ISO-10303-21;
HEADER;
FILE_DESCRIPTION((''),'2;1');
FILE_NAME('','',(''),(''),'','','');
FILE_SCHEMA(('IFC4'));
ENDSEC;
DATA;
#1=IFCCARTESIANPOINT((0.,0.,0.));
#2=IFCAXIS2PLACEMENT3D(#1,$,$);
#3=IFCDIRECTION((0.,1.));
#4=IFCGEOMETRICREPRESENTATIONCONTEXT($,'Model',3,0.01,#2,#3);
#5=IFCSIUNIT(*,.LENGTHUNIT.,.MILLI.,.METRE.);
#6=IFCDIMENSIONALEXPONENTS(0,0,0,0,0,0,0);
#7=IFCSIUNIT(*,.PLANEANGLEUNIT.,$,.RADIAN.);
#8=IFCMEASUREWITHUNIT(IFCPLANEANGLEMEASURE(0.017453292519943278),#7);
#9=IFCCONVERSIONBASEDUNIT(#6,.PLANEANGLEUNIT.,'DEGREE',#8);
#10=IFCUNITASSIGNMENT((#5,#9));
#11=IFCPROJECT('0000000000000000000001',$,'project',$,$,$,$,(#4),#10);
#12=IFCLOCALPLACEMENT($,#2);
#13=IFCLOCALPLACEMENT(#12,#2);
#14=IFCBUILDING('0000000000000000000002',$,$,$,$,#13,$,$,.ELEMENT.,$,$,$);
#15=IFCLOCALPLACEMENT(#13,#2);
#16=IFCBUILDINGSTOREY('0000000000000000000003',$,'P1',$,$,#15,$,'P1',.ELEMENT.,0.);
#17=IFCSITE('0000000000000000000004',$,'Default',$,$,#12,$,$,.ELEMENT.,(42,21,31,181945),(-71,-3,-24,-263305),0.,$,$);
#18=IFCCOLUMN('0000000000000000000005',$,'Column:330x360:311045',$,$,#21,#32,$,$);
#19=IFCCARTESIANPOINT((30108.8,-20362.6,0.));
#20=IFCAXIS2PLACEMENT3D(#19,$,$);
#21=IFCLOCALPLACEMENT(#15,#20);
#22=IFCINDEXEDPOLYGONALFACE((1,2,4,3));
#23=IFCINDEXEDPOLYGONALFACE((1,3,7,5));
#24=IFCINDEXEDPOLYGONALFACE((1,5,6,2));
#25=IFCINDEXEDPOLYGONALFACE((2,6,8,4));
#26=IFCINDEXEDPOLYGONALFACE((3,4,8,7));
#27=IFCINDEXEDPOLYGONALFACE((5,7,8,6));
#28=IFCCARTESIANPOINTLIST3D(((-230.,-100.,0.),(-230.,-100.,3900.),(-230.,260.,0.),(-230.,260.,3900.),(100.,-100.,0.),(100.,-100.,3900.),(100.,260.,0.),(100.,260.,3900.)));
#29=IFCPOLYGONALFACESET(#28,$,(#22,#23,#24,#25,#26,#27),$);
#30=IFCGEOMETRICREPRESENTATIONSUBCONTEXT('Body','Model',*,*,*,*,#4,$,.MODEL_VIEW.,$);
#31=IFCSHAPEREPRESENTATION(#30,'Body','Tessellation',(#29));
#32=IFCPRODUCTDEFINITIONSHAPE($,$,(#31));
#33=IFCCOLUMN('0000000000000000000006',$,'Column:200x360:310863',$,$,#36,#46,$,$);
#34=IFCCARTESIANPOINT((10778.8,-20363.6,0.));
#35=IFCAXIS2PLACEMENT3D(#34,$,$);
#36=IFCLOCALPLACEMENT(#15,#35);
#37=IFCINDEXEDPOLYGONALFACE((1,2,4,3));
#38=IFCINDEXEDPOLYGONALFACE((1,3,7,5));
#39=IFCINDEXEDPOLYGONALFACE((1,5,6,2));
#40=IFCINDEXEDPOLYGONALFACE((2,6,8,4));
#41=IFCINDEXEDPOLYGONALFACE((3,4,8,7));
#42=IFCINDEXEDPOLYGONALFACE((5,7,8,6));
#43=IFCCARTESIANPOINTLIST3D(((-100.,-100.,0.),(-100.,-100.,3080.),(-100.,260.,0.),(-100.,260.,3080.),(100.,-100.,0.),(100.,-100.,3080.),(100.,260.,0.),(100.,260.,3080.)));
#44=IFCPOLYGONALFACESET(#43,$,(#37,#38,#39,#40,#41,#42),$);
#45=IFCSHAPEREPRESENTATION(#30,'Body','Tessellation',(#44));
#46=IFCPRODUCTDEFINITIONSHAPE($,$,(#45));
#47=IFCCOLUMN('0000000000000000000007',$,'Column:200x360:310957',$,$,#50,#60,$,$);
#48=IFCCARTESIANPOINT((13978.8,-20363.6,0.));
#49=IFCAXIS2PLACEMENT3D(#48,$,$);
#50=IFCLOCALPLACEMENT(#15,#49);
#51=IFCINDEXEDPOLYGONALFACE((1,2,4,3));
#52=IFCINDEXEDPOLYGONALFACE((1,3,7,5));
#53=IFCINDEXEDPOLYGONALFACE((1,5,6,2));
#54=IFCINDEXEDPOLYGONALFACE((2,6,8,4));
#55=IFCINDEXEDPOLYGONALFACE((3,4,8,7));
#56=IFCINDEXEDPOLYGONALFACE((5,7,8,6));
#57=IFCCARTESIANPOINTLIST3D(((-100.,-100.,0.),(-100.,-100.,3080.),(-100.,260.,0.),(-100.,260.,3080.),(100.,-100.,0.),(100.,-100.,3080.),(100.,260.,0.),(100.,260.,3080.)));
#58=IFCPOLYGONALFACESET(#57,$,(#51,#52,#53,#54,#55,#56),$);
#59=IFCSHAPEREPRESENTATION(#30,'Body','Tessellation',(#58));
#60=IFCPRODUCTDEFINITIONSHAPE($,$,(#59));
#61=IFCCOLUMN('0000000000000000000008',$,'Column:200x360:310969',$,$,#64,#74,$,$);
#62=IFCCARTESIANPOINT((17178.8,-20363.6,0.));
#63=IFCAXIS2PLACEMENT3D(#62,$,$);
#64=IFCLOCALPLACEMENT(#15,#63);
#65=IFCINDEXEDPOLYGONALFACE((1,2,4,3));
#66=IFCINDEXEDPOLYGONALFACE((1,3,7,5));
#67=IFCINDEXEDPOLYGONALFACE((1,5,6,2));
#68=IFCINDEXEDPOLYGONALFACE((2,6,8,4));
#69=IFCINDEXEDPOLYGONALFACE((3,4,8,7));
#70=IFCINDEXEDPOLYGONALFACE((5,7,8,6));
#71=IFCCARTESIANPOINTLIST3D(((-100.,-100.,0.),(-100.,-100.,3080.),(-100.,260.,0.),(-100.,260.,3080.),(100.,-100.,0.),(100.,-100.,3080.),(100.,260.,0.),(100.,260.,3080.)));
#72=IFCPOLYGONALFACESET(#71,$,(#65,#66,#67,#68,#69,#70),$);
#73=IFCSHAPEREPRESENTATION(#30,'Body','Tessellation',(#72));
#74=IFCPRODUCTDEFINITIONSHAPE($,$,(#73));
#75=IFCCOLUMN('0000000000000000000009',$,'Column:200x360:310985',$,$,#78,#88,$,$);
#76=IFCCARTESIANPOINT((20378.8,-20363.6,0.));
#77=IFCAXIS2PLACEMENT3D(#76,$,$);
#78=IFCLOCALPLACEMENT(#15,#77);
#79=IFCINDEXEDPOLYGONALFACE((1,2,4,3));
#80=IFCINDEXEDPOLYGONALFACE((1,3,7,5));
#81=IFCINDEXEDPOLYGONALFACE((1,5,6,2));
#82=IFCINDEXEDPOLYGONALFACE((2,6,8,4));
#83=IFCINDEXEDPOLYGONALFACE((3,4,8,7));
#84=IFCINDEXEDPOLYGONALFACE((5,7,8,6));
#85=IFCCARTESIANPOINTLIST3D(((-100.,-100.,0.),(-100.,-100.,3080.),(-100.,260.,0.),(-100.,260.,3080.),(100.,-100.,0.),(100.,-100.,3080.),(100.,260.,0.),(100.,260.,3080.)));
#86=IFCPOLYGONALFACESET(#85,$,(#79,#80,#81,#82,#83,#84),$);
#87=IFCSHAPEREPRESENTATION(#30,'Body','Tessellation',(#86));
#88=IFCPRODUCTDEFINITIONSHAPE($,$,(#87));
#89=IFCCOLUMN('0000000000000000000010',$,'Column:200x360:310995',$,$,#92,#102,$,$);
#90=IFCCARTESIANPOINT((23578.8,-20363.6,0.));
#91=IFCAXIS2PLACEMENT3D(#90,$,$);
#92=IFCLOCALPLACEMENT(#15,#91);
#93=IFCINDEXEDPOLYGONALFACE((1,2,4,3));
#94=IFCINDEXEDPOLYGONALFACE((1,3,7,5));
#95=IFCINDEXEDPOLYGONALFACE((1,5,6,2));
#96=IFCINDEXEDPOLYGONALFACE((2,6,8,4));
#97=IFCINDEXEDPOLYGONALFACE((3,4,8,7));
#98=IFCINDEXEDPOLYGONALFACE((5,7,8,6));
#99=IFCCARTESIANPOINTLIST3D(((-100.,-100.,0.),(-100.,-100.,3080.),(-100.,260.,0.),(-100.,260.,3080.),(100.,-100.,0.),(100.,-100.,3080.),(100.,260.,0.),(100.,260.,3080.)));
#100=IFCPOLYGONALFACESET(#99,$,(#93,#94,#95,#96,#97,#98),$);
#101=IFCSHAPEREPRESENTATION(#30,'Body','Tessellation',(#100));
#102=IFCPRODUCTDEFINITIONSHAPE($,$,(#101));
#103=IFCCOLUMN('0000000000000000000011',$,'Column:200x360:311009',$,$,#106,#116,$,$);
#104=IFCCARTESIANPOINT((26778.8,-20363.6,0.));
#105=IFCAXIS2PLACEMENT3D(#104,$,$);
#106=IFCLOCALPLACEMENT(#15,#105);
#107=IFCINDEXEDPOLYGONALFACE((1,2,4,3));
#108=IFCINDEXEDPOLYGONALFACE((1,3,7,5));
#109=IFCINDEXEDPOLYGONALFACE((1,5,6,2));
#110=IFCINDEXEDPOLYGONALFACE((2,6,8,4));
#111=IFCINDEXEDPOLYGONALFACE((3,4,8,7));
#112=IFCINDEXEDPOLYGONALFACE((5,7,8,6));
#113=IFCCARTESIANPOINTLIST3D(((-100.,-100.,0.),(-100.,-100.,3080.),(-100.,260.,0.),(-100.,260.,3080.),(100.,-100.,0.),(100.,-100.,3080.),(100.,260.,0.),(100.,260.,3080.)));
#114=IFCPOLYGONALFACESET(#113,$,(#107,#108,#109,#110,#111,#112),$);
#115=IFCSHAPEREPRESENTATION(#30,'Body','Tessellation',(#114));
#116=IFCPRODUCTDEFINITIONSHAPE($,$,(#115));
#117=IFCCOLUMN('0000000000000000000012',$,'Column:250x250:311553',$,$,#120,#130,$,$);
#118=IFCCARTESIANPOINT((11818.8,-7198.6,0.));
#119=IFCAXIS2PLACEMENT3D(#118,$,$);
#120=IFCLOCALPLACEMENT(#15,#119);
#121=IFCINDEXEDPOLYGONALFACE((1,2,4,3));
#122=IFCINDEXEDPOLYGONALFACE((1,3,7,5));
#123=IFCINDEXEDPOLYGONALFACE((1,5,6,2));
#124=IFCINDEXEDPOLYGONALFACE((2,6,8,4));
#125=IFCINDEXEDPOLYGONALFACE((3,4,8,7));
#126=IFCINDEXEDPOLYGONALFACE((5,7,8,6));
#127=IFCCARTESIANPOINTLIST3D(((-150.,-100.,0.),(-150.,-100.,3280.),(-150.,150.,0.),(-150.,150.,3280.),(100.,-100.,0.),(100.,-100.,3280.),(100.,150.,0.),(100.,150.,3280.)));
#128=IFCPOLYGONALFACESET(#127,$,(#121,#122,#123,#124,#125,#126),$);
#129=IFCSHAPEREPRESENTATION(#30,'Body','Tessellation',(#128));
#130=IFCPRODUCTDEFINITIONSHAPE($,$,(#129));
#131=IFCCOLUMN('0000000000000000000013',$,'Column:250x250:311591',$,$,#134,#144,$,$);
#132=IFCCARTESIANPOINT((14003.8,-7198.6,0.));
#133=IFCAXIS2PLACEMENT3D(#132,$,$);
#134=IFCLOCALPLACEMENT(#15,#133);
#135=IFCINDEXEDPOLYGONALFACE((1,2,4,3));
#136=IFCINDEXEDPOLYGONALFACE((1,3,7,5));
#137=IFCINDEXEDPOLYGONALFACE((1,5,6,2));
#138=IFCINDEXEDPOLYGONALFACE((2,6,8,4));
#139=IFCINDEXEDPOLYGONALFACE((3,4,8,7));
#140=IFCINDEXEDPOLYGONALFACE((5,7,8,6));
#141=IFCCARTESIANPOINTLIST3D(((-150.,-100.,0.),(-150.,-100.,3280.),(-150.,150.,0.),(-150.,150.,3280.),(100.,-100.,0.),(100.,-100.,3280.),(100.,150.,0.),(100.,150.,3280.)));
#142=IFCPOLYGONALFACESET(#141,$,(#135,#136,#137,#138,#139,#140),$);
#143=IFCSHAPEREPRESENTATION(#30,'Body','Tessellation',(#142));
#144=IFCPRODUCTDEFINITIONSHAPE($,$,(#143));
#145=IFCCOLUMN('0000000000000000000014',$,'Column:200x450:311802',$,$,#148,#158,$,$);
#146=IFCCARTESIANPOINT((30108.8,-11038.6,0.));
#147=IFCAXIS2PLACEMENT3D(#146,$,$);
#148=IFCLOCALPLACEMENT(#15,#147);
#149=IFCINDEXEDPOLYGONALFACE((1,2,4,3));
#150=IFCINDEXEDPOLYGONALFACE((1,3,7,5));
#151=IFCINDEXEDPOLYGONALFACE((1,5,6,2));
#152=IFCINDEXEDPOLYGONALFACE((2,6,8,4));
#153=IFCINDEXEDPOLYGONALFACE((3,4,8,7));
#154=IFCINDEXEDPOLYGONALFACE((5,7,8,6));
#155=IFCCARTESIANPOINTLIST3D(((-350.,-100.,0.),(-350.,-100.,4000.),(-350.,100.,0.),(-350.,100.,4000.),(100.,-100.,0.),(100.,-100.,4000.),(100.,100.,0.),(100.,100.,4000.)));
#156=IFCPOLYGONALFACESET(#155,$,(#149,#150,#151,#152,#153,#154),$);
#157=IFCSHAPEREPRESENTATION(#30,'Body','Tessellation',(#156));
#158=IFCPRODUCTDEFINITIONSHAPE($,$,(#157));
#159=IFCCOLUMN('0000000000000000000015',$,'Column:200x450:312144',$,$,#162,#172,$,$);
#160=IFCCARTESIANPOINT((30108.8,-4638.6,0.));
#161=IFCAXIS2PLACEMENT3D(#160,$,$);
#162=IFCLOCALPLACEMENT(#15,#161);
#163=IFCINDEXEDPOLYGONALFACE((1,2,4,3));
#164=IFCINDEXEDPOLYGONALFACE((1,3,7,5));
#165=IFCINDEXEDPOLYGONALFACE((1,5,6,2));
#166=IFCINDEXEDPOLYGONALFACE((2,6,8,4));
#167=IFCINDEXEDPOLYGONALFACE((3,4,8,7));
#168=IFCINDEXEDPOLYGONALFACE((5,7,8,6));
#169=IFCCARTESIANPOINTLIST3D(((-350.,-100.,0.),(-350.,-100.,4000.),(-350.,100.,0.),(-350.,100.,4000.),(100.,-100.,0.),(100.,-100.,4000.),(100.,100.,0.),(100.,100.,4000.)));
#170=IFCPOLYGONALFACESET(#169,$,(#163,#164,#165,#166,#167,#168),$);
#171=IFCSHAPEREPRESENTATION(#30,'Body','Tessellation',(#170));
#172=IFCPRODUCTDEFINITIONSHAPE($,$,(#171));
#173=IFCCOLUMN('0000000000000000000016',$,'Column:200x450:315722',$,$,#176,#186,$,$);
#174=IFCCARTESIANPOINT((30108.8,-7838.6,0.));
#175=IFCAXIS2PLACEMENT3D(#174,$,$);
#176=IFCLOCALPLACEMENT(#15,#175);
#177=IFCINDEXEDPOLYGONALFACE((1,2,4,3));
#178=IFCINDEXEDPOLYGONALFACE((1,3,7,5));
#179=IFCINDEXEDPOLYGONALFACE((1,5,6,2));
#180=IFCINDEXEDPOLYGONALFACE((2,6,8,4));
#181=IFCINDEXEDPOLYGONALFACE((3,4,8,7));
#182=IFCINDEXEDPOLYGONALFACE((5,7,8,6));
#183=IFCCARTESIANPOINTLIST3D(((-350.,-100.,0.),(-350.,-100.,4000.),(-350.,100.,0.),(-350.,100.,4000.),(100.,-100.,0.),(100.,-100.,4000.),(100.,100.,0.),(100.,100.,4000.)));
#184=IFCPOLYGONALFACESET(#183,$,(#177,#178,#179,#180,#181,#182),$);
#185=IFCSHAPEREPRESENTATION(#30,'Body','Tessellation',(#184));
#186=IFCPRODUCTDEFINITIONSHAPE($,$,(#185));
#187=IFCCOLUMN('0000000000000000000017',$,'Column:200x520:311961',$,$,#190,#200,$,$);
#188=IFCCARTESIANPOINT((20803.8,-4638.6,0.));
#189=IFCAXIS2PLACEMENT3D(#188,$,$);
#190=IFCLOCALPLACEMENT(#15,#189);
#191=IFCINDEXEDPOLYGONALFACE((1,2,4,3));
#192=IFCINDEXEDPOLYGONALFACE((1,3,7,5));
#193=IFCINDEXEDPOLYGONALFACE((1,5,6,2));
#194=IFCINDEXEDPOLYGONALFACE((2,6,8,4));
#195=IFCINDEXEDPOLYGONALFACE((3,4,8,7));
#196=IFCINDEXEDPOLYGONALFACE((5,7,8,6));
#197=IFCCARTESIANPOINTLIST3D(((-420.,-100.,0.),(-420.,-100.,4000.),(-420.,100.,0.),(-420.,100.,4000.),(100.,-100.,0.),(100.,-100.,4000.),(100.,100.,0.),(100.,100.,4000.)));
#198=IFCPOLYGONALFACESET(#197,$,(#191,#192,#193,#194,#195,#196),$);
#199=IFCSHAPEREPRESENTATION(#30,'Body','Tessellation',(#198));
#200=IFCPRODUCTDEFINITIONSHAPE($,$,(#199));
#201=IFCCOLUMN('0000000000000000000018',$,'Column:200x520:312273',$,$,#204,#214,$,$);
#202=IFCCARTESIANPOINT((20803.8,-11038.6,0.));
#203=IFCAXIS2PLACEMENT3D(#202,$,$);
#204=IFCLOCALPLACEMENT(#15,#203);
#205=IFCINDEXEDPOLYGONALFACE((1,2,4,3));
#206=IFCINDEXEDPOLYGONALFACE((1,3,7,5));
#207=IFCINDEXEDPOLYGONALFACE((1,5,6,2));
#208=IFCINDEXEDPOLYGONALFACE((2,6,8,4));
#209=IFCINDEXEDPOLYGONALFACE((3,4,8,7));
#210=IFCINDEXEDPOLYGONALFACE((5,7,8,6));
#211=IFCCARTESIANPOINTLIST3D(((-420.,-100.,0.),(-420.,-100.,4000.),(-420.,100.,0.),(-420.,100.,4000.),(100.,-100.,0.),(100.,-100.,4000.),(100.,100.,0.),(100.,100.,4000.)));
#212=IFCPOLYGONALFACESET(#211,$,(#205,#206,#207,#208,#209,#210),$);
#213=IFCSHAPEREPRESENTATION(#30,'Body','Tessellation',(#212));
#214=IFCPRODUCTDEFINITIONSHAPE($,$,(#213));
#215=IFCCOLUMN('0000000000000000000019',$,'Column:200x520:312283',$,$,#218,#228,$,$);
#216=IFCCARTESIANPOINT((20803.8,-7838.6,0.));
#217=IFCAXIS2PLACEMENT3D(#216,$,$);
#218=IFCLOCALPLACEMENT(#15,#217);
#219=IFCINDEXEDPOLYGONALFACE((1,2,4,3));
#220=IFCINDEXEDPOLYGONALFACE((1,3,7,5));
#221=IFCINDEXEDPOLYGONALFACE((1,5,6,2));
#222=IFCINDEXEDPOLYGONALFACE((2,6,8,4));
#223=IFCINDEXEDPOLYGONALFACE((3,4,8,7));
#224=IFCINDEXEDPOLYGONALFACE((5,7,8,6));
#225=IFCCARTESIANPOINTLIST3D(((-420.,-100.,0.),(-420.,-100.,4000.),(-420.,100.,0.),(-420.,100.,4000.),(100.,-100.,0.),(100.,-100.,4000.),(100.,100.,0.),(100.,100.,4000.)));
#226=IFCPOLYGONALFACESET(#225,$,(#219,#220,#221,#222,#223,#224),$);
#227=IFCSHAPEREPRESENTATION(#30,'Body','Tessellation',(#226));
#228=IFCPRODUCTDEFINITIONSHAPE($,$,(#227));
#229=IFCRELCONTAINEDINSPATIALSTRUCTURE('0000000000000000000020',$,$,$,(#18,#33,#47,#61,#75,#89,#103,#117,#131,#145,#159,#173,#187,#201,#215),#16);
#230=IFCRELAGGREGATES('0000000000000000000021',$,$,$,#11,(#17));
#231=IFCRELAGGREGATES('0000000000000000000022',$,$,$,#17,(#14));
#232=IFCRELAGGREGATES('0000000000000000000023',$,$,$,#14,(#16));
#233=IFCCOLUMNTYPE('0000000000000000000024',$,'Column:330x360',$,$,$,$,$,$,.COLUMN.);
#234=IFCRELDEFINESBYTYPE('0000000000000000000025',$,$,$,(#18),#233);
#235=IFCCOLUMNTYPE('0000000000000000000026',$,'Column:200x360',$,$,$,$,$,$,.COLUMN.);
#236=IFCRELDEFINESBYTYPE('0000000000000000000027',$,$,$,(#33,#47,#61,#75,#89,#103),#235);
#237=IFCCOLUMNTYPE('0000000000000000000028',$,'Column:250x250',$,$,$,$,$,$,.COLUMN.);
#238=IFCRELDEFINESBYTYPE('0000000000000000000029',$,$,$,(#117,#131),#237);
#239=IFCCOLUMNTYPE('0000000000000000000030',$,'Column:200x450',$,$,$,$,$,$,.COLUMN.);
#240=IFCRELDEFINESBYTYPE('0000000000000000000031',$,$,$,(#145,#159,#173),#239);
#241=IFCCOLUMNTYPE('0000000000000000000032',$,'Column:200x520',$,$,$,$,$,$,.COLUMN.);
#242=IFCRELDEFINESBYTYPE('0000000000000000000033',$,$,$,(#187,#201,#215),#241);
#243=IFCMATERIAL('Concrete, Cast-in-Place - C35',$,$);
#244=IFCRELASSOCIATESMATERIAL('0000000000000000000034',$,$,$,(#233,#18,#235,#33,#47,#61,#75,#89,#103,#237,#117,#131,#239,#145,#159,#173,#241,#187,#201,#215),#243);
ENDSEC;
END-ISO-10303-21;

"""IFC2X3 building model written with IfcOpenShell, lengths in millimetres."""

from ifc_helpers import new_model, entity, si_unit, converted_unit, direction, frame, origin, origin_2d_with_axis, place, context, subcontext, project, spatial, rectangle, extrude, source, transform, mapped, material, type_object, type_shapes, element, save


model = new_model("IFC2X3")

# Units and contexts
model_context = context("Model", 3, precision=0.01, world=origin(), true_north=direction((0.0, 1.0)))
body_context = subcontext(model_context, "Body", "Model", "MODEL_VIEW")
ifc_project = project(units=[si_unit("LENGTHUNIT", "METRE", prefix="MILLI"), converted_unit("PLANEANGLEUNIT", "DEGREE", entity("IfcPlaneAngleMeasure", 0.017453292519943278), si_unit("PLANEANGLEUNIT", "RADIAN"), dimensions=[0, 0, 0, 0, 0, 0, 0])], contexts=[model_context])

# Site, building, storey
site_placement = place(None, origin())
site = spatial("IfcSite", under=ifc_project, at=site_placement, Name="Default", CompositionType="ELEMENT", RefLatitude=(42, 21, 31, 181945), RefLongitude=(-71, -3, -24, -263305), RefElevation=0.0)
building_placement = place(site_placement, origin())
building = spatial("IfcBuilding", under=site, at=building_placement, CompositionType="ELEMENT")
storey_placement = place(building_placement, origin())
storey = spatial("IfcBuildingStorey", under=building, at=storey_placement, Name="P1", LongName="P1", CompositionType="ELEMENT", Elevation=0.0)

# Columns
ifc_material_1 = material(Name="Concrete, Cast-in-Place - C35")
column_type_1 = type_object("IfcColumnType", Name="Column:330x360", PredefinedType="COLUMN", material=ifc_material_1)
shared_shape_1 = source(origin(), body_context, "Body", "SweptSolid", [
    extrude(rectangle(XDim=330.0, YDim=360.0, at=origin_2d_with_axis()), frame((-65.0, 80.0, 0.0), z_axis=(0.0, 0.0, 1.0), x_axis=(-1.0, 0.0, 0.0)), (0.0, 0.0, 1.0), 3900.0),
])
type_shapes(column_type_1, [shared_shape_1])
column_placement = place(storey_placement, frame((30108.8, -20362.6, 0.0)))
element("IfcColumn", 1, at=column_placement, inside=storey, type_object=column_type_1, material=ifc_material_1, Name="Column:330x360:311045", context=body_context, shape_type="MappedRepresentation", body=[
    mapped(shared_shape_1, transform((0.0, 0.0, 0.0), scale=1.0)),
])
column_type_2 = type_object("IfcColumnType", Name="Column:200x360", PredefinedType="COLUMN", material=ifc_material_1)
shared_shape_2 = source(origin(), body_context, "Body", "SweptSolid", [
    extrude(rectangle(XDim=200.0, YDim=360.0, at=origin_2d_with_axis()), frame((0.0, 80.0, 0.0), z_axis=(0.0, 0.0, 1.0), x_axis=(-1.0, 0.0, 0.0)), (0.0, 0.0, 1.0), 3080.0),
])
type_shapes(column_type_2, [shared_shape_2])
for number, where, name in (
    (2, (10778.8, -20363.6, 0.0), "Column:200x360:310863"),
    (3, (13978.8, -20363.6, 0.0), "Column:200x360:310957"),
    (4, (17178.8, -20363.6, 0.0), "Column:200x360:310969"),
    (5, (20378.8, -20363.6, 0.0), "Column:200x360:310985"),
    (6, (23578.8, -20363.6, 0.0), "Column:200x360:310995"),
    (7, (26778.8, -20363.6, 0.0), "Column:200x360:311009"),
):
    element("IfcColumn", number, at=place(storey_placement, frame(where)), inside=storey, type_object=column_type_2, material=ifc_material_1, Name=name, context=body_context, shape_type="MappedRepresentation", body=[
        mapped(shared_shape_2, transform((0.0, 0.0, 0.0), scale=1.0)),
    ])
column_type_3 = type_object("IfcColumnType", Name="Column:250x250", PredefinedType="COLUMN", material=ifc_material_1)
shared_shape_3 = source(origin(), body_context, "Body", "SweptSolid", [
    extrude(rectangle(XDim=250.0, YDim=250.0, at=origin_2d_with_axis()), frame((-25.0, 25.0, 0.0), z_axis=(0.0, 0.0, 1.0), x_axis=(-1.0, 0.0, 0.0)), (0.0, 0.0, 1.0), 3280.0),
])
type_shapes(column_type_3, [shared_shape_3])
for number, where, name in (
    (8, (11818.8, -7198.6, 0.0), "Column:250x250:311553"),
    (9, (14003.8, -7198.6, 0.0), "Column:250x250:311591"),
):
    element("IfcColumn", number, at=place(storey_placement, frame(where)), inside=storey, type_object=column_type_3, material=ifc_material_1, Name=name, context=body_context, shape_type="MappedRepresentation", body=[
        mapped(shared_shape_3, transform((0.0, 0.0, 0.0), scale=1.0)),
    ])
column_type_4 = type_object("IfcColumnType", Name="Column:200x450", PredefinedType="COLUMN", material=ifc_material_1)
shared_shape_4 = source(origin(), body_context, "Body", "SweptSolid", [
    extrude(rectangle(XDim=450.0, YDim=200.0, at=origin_2d_with_axis()), frame((-125.0, 0.0, 0.0), z_axis=(0.0, 0.0, 1.0), x_axis=(-1.0, 0.0, 0.0)), (0.0, 0.0, 1.0), 4000.0),
])
type_shapes(column_type_4, [shared_shape_4])
for number, where, name in (
    (10, (30108.8, -11038.6, 0.0), "Column:200x450:311802"),
    (11, (30108.8, -4638.6, 0.0), "Column:200x450:312144"),
    (12, (30108.8, -7838.6, 0.0), "Column:200x450:315722"),
):
    element("IfcColumn", number, at=place(storey_placement, frame(where)), inside=storey, type_object=column_type_4, material=ifc_material_1, Name=name, context=body_context, shape_type="MappedRepresentation", body=[
        mapped(shared_shape_4, transform((0.0, 0.0, 0.0), scale=1.0)),
    ])
column_type_5 = type_object("IfcColumnType", Name="Column:200x520", PredefinedType="COLUMN", material=ifc_material_1)
shared_shape_5 = source(origin(), body_context, "Body", "SweptSolid", [
    extrude(rectangle(XDim=520.0, YDim=200.0, at=origin_2d_with_axis()), frame((-160.0, 0.0, 0.0), z_axis=(0.0, 0.0, 1.0), x_axis=(-1.0, 0.0, 0.0)), (0.0, 0.0, 1.0), 4000.0),
])
type_shapes(column_type_5, [shared_shape_5])
for number, where, name in (
    (13, (20803.8, -4638.6, 0.0), "Column:200x520:311961"),
    (14, (20803.8, -11038.6, 0.0), "Column:200x520:312273"),
    (15, (20803.8, -7838.6, 0.0), "Column:200x520:312283"),
):
    element("IfcColumn", number, at=place(storey_placement, frame(where)), inside=storey, type_object=column_type_5, material=ifc_material_1, Name=name, context=body_context, shape_type="MappedRepresentation", body=[
        mapped(shared_shape_5, transform((0.0, 0.0, 0.0), scale=1.0)),
    ])

save(model, "model.ifc")
